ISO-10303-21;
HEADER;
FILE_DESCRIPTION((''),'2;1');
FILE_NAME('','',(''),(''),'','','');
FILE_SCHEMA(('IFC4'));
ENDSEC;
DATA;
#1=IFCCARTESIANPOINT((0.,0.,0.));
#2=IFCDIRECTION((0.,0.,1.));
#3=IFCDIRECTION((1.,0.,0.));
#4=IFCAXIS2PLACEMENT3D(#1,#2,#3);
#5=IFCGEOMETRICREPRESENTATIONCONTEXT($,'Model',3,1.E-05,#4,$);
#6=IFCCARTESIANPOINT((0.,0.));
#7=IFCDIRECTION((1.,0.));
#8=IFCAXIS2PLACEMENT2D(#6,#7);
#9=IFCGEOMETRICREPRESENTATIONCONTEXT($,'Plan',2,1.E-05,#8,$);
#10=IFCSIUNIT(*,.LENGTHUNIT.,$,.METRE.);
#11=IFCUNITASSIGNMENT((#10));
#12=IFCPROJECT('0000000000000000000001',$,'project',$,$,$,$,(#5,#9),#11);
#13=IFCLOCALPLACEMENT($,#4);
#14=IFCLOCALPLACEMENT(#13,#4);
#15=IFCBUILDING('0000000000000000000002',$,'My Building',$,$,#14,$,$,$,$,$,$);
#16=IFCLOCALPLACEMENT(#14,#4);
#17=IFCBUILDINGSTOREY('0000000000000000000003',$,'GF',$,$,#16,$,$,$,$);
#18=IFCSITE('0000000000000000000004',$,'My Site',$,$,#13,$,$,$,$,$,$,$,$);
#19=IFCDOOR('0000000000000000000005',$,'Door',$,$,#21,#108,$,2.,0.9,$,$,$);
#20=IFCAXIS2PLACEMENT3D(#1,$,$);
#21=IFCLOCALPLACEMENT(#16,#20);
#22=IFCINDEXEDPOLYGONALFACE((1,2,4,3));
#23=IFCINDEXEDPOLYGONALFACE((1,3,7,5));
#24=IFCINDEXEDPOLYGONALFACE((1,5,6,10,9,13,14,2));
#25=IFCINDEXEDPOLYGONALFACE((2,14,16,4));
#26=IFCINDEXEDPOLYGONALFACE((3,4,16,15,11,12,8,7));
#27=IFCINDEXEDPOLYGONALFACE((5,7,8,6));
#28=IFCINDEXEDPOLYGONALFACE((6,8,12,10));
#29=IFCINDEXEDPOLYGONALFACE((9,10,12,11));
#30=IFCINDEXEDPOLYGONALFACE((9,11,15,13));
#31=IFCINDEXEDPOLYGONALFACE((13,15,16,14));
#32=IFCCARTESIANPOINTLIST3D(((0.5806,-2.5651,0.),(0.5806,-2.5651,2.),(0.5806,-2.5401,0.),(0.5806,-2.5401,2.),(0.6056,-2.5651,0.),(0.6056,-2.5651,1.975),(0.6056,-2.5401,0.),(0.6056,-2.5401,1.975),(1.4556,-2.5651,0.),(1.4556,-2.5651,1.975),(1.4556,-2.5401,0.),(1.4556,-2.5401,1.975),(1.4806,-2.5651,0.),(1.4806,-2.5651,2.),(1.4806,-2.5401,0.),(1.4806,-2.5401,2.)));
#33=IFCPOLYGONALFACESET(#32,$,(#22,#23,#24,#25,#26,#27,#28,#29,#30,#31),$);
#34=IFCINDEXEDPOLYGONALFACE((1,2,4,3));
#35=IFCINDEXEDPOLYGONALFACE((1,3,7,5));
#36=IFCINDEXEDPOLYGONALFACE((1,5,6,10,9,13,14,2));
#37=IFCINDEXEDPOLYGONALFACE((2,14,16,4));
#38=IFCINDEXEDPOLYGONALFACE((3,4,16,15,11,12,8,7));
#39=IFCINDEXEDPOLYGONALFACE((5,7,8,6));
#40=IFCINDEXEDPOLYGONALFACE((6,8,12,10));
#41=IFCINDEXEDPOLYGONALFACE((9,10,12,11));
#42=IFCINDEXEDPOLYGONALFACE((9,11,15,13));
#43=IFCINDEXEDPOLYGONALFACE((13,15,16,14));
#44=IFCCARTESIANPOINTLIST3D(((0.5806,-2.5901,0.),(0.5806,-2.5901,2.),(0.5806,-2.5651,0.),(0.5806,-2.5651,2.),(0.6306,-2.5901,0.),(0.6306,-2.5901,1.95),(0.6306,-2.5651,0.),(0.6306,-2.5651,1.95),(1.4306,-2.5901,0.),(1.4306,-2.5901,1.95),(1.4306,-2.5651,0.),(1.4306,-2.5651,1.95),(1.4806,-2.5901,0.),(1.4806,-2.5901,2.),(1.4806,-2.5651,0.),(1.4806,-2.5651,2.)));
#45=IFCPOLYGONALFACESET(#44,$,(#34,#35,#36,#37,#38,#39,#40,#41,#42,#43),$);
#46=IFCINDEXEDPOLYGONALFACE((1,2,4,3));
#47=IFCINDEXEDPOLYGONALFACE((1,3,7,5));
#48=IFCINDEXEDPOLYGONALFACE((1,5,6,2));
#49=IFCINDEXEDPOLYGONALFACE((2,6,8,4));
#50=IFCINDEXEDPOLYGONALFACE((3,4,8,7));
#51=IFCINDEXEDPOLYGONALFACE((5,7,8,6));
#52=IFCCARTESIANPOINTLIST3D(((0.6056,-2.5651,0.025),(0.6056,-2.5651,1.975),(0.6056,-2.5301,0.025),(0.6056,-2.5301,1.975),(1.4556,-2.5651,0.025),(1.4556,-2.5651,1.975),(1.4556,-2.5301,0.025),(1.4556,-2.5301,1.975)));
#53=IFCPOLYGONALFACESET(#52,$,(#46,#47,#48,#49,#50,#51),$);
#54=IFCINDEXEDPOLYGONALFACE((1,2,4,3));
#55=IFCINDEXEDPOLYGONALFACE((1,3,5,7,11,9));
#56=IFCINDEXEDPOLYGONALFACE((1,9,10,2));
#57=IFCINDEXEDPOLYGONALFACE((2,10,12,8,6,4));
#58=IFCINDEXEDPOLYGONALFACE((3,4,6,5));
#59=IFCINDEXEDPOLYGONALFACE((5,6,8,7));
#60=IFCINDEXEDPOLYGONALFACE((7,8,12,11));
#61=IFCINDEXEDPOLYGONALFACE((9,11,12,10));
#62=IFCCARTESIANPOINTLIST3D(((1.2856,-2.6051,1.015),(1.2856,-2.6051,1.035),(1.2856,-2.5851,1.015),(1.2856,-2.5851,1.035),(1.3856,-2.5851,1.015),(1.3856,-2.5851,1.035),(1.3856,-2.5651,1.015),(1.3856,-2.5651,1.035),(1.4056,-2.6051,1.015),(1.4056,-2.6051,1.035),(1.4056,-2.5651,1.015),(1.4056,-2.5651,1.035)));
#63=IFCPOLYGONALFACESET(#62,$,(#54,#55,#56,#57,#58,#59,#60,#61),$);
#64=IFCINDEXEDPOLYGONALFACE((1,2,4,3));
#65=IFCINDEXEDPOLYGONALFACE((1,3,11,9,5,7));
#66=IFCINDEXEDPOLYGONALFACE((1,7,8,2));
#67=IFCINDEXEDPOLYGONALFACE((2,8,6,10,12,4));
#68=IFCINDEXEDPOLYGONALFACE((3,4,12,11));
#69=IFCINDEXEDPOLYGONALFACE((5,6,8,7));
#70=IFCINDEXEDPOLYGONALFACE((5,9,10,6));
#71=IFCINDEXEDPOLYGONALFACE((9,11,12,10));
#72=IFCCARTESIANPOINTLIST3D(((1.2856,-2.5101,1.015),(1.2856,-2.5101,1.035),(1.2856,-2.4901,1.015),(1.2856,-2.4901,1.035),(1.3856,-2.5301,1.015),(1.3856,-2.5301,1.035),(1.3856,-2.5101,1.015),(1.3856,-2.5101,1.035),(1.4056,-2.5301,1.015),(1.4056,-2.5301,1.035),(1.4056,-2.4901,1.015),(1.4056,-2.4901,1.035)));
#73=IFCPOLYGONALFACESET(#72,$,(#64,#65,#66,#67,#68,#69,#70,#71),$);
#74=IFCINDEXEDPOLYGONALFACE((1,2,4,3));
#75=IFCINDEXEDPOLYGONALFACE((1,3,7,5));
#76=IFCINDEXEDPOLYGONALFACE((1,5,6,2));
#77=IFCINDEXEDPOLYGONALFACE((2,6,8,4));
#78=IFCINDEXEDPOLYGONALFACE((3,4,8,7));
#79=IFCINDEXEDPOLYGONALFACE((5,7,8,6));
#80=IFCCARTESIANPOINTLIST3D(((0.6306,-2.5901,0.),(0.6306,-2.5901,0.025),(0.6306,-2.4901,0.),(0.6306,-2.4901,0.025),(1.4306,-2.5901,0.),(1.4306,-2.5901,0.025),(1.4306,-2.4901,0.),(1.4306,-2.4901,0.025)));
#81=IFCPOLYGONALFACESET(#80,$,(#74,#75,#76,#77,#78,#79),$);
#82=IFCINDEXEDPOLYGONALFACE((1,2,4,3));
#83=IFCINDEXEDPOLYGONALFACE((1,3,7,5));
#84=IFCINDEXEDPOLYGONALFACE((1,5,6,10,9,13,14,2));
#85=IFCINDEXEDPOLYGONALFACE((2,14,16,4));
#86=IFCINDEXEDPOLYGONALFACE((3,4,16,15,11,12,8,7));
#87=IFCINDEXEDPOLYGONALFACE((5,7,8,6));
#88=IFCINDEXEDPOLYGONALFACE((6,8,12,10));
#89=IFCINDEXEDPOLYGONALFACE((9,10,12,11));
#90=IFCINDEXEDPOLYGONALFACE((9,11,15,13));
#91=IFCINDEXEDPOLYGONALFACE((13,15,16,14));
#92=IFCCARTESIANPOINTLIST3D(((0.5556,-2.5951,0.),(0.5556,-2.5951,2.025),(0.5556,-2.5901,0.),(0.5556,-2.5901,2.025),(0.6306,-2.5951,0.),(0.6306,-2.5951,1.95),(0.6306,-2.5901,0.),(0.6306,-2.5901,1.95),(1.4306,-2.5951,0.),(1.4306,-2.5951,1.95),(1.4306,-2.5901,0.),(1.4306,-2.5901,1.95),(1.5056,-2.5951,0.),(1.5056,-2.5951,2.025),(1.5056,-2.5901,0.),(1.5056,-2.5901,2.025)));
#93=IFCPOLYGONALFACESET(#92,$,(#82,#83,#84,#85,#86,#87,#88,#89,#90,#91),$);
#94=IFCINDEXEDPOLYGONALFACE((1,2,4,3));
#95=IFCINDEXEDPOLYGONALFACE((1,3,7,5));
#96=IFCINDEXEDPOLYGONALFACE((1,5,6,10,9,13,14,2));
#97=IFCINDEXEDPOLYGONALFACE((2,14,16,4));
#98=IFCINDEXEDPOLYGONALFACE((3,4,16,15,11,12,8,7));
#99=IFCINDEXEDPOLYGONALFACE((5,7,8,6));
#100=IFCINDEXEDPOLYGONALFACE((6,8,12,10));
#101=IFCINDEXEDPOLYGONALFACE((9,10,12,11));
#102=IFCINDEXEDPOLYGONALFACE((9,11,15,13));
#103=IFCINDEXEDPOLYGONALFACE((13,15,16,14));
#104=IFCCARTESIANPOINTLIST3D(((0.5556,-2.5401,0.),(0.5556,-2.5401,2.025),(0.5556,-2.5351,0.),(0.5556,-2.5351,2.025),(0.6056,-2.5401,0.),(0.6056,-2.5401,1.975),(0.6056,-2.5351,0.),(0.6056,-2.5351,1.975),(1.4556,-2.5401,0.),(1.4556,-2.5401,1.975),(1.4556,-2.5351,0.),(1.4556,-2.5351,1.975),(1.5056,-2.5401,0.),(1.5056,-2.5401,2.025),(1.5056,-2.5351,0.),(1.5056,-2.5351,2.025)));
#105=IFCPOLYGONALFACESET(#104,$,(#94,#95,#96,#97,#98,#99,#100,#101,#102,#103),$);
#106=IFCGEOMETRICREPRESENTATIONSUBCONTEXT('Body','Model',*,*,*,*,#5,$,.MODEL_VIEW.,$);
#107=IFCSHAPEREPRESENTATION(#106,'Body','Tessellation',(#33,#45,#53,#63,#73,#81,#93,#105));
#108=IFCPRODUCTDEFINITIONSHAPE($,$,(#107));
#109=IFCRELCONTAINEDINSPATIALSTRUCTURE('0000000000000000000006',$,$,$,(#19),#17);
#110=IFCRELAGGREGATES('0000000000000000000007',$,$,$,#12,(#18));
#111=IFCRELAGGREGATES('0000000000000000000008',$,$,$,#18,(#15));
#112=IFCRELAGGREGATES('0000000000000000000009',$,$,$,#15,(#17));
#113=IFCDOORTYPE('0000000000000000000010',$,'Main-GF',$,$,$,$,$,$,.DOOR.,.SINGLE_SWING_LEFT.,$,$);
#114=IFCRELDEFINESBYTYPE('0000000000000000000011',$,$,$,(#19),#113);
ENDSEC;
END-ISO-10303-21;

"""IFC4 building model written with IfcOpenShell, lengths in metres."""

from ifc_helpers import new_model, entity, si_unit, frame, origin_with_axes, origin_2d_with_axis, place, context, subcontext, project, spatial, line, indexed_curve, outline, extrude, shape, source, transform, mapped, type_object, type_shapes, element, save


model = new_model("IFC4")

# Units and contexts
model_context = context("Model", 3, precision=1e-05, world=origin_with_axes())
plan_context = context("Plan", 2, precision=1e-05, world=origin_2d_with_axis())
body_context_1 = subcontext(model_context, "Body", "Model", "MODEL_VIEW")
body_context_2 = subcontext(plan_context, "Body", "Plan", "PLAN_VIEW")
ifc_project = project(units=[si_unit("LENGTHUNIT", "METRE")], contexts=[model_context, plan_context])

# Site, building, storey
site_placement = place(None, origin_with_axes())
site = spatial("IfcSite", under=ifc_project, at=site_placement, Name="My Site")
building_placement = place(site_placement, origin_with_axes())
building = spatial("IfcBuilding", under=site, at=building_placement, Name="My Building")
storey_placement = place(building_placement, origin_with_axes())
storey = spatial("IfcBuildingStorey", under=building, at=storey_placement, Name="GF")

# Door
door_type_1 = type_object("IfcDoorType", Name="Main-GF", OperationType="SINGLE_SWING_LEFT", PredefinedType="DOOR")
shared_shape_1 = source(origin_with_axes(), body_context_1, "Body", "SweptSolid", [
    extrude(outline(indexed_curve([(0.0, 0.0), (0.0, 2.0), (0.9, 2.0), (0.9, 0.0), (0.875, 0.0), (0.875, 1.975), (0.025, 1.975), (0.025, 0.0)], segments=[line(1, 2, 3, 4, 5, 6, 7, 8, 1)])), frame((0.0, 0.025, 0.0), z_axis=(0.0, -1.0, 0.0), x_axis=(1.0, 0.0, 0.0)), (0.0, 0.0, -1.0), 0.025),
    extrude(outline(indexed_curve([(0.0, 0.0), (0.0, 2.0), (0.9, 2.0), (0.9, 0.0), (0.85, 0.0), (0.85, 1.95), (0.05, 1.95), (0.05, 0.0)], segments=[line(1, 2, 3, 4, 5, 6, 7, 8, 1)])), frame((0.0, 0.0, 0.0), z_axis=(0.0, -1.0, 0.0), x_axis=(1.0, 0.0, 0.0)), (0.0, 0.0, -1.0), 0.025),
    extrude(outline(indexed_curve([(0.0, 0.0), (0.85, 0.0), (0.85, 0.035), (0.0, 0.035)], segments=[line(1, 2, 3, 4, 1)])), frame((0.025, 0.025, 0.025), z_axis=(0.0, 0.0, 1.0), x_axis=(1.0, 0.0, 0.0)), (0.0, 0.0, 1.0), 1.95),
    extrude(outline(indexed_curve([(0.0, 0.0), (0.0, -0.04), (-0.12, -0.04), (-0.12, -0.02), (-0.02, -0.02), (-0.02, 0.0)], segments=[line(1, 2, 3, 4, 5, 6, 1)])), frame((0.825, 0.025, 1.015), z_axis=(0.0, 0.0, 1.0), x_axis=(1.0, 0.0, 0.0)), (0.0, 0.0, 1.0), 0.02),
    extrude(outline(indexed_curve([(0.0, 0.0), (0.0, 0.04), (-0.12, 0.04), (-0.12, 0.02), (-0.02, 0.02), (-0.02, 0.0)], segments=[line(1, 2, 3, 4, 5, 6, 1)])), frame((0.825, 0.06, 1.015), z_axis=(0.0, 0.0, 1.0), x_axis=(1.0, 0.0, 0.0)), (0.0, 0.0, 1.0), 0.02),
    extrude(outline(indexed_curve([(0.0, 0.0), (0.8, 0.0), (0.8, 0.1), (0.0, 0.1)], segments=[line(1, 2, 3, 4, 1)])), frame((0.05, 0.0, 0.0), z_axis=(0.0, 0.0, 1.0), x_axis=(1.0, 0.0, 0.0)), (0.0, 0.0, 1.0), 0.025),
    extrude(outline(indexed_curve([(0.0, 0.0), (0.0, 2.025), (0.95, 2.025), (0.95, 0.0), (0.875, 0.0), (0.875, 1.95), (0.075, 1.95), (0.075, 0.0)], segments=[line(1, 2, 3, 4, 5, 6, 7, 8, 1)])), frame((-0.025, -0.005, 0.0), z_axis=(0.0, -1.0, 0.0), x_axis=(1.0, 0.0, 0.0)), (0.0, 0.0, -1.0), 0.005),
    extrude(outline(indexed_curve([(0.0, 0.0), (0.0, 2.025), (0.95, 2.025), (0.95, 0.0), (0.9, 0.0), (0.9, 1.975), (0.05, 1.975), (0.05, 0.0)], segments=[line(1, 2, 3, 4, 5, 6, 7, 8, 1)])), frame((-0.025, 0.05, 0.0), z_axis=(0.0, -1.0, 0.0), x_axis=(1.0, 0.0, 0.0)), (0.0, 0.0, -1.0), 0.005),
])
shared_shape_2 = source(origin_with_axes(), body_context_2, "Body", "Curve2D", [
    entity("IfcIndexedPolyCurve", entity("IfcCartesianPointList2D", [[0.0, 0.0], [0.0, 0.05], [0.025, 0.05], [0.025, 0.025], [0.05, 0.025], [0.05, 0.0]]), [entity("IfcLineIndex", [1, 2, 3, 4, 5, 6, 1])]),
    entity("IfcIndexedPolyCurve", entity("IfcCartesianPointList2D", [[0.9, 0.0], [0.9, 0.05], [0.875, 0.05], [0.875, 0.025], [0.85, 0.025], [0.85, 0.0]]), [entity("IfcLineIndex", [1, 2, 3, 4, 5, 6, 1])]),
    entity("IfcTrimmedCurve", entity("IfcEllipse", entity("IfcAxis2Placement2D", entity("IfcCartesianPoint", [0.06, 0.05]), entity("IfcDirection", [1.0, 0.0])), 0.815, 0.85), [entity("IfcCartesianPoint", [0.875, 0.05])], [entity("IfcCartesianPoint", [0.06, 0.9])], True, "CARTESIAN"),
    entity("IfcIndexedPolyCurve", entity("IfcCartesianPointList2D", [[0.025, 0.05], [0.06, 0.05], [0.06, 0.9], [0.025, 0.9]]), [entity("IfcLineIndex", [1, 2, 3, 4, 1])]),
])
type_shapes(door_type_1, [shared_shape_1, shared_shape_2])
door_1_placement = place(storey_placement, frame((0.5806, -2.5901, 0.0), z_axis=(0.0, 0.0, 1.0), x_axis=(1.0, 0.0, 0.0)))
element("IfcDoor", 1, at=door_1_placement, inside=storey, type_object=door_type_1, Name="Door", OverallHeight=2.0, OverallWidth=0.9, shapes=[
    shape(body_context_1, "Body", "MappedRepresentation", [mapped(shared_shape_1, transform((0.0, 0.0, 0.0), x_axis=(1.0, 0.0, 0.0), y_axis=(0.0, 1.0, 0.0), z_axis=(0.0, 0.0, 1.0), scale=1.0))]),
    shape(body_context_2, "Body", "MappedRepresentation", [mapped(shared_shape_2, transform((0.0, 0.0, 0.0), x_axis=(1.0, 0.0, 0.0), y_axis=(0.0, 1.0, 0.0), z_axis=(0.0, 0.0, 1.0), scale=1.0))]),
])

save(model, "model.ifc")
